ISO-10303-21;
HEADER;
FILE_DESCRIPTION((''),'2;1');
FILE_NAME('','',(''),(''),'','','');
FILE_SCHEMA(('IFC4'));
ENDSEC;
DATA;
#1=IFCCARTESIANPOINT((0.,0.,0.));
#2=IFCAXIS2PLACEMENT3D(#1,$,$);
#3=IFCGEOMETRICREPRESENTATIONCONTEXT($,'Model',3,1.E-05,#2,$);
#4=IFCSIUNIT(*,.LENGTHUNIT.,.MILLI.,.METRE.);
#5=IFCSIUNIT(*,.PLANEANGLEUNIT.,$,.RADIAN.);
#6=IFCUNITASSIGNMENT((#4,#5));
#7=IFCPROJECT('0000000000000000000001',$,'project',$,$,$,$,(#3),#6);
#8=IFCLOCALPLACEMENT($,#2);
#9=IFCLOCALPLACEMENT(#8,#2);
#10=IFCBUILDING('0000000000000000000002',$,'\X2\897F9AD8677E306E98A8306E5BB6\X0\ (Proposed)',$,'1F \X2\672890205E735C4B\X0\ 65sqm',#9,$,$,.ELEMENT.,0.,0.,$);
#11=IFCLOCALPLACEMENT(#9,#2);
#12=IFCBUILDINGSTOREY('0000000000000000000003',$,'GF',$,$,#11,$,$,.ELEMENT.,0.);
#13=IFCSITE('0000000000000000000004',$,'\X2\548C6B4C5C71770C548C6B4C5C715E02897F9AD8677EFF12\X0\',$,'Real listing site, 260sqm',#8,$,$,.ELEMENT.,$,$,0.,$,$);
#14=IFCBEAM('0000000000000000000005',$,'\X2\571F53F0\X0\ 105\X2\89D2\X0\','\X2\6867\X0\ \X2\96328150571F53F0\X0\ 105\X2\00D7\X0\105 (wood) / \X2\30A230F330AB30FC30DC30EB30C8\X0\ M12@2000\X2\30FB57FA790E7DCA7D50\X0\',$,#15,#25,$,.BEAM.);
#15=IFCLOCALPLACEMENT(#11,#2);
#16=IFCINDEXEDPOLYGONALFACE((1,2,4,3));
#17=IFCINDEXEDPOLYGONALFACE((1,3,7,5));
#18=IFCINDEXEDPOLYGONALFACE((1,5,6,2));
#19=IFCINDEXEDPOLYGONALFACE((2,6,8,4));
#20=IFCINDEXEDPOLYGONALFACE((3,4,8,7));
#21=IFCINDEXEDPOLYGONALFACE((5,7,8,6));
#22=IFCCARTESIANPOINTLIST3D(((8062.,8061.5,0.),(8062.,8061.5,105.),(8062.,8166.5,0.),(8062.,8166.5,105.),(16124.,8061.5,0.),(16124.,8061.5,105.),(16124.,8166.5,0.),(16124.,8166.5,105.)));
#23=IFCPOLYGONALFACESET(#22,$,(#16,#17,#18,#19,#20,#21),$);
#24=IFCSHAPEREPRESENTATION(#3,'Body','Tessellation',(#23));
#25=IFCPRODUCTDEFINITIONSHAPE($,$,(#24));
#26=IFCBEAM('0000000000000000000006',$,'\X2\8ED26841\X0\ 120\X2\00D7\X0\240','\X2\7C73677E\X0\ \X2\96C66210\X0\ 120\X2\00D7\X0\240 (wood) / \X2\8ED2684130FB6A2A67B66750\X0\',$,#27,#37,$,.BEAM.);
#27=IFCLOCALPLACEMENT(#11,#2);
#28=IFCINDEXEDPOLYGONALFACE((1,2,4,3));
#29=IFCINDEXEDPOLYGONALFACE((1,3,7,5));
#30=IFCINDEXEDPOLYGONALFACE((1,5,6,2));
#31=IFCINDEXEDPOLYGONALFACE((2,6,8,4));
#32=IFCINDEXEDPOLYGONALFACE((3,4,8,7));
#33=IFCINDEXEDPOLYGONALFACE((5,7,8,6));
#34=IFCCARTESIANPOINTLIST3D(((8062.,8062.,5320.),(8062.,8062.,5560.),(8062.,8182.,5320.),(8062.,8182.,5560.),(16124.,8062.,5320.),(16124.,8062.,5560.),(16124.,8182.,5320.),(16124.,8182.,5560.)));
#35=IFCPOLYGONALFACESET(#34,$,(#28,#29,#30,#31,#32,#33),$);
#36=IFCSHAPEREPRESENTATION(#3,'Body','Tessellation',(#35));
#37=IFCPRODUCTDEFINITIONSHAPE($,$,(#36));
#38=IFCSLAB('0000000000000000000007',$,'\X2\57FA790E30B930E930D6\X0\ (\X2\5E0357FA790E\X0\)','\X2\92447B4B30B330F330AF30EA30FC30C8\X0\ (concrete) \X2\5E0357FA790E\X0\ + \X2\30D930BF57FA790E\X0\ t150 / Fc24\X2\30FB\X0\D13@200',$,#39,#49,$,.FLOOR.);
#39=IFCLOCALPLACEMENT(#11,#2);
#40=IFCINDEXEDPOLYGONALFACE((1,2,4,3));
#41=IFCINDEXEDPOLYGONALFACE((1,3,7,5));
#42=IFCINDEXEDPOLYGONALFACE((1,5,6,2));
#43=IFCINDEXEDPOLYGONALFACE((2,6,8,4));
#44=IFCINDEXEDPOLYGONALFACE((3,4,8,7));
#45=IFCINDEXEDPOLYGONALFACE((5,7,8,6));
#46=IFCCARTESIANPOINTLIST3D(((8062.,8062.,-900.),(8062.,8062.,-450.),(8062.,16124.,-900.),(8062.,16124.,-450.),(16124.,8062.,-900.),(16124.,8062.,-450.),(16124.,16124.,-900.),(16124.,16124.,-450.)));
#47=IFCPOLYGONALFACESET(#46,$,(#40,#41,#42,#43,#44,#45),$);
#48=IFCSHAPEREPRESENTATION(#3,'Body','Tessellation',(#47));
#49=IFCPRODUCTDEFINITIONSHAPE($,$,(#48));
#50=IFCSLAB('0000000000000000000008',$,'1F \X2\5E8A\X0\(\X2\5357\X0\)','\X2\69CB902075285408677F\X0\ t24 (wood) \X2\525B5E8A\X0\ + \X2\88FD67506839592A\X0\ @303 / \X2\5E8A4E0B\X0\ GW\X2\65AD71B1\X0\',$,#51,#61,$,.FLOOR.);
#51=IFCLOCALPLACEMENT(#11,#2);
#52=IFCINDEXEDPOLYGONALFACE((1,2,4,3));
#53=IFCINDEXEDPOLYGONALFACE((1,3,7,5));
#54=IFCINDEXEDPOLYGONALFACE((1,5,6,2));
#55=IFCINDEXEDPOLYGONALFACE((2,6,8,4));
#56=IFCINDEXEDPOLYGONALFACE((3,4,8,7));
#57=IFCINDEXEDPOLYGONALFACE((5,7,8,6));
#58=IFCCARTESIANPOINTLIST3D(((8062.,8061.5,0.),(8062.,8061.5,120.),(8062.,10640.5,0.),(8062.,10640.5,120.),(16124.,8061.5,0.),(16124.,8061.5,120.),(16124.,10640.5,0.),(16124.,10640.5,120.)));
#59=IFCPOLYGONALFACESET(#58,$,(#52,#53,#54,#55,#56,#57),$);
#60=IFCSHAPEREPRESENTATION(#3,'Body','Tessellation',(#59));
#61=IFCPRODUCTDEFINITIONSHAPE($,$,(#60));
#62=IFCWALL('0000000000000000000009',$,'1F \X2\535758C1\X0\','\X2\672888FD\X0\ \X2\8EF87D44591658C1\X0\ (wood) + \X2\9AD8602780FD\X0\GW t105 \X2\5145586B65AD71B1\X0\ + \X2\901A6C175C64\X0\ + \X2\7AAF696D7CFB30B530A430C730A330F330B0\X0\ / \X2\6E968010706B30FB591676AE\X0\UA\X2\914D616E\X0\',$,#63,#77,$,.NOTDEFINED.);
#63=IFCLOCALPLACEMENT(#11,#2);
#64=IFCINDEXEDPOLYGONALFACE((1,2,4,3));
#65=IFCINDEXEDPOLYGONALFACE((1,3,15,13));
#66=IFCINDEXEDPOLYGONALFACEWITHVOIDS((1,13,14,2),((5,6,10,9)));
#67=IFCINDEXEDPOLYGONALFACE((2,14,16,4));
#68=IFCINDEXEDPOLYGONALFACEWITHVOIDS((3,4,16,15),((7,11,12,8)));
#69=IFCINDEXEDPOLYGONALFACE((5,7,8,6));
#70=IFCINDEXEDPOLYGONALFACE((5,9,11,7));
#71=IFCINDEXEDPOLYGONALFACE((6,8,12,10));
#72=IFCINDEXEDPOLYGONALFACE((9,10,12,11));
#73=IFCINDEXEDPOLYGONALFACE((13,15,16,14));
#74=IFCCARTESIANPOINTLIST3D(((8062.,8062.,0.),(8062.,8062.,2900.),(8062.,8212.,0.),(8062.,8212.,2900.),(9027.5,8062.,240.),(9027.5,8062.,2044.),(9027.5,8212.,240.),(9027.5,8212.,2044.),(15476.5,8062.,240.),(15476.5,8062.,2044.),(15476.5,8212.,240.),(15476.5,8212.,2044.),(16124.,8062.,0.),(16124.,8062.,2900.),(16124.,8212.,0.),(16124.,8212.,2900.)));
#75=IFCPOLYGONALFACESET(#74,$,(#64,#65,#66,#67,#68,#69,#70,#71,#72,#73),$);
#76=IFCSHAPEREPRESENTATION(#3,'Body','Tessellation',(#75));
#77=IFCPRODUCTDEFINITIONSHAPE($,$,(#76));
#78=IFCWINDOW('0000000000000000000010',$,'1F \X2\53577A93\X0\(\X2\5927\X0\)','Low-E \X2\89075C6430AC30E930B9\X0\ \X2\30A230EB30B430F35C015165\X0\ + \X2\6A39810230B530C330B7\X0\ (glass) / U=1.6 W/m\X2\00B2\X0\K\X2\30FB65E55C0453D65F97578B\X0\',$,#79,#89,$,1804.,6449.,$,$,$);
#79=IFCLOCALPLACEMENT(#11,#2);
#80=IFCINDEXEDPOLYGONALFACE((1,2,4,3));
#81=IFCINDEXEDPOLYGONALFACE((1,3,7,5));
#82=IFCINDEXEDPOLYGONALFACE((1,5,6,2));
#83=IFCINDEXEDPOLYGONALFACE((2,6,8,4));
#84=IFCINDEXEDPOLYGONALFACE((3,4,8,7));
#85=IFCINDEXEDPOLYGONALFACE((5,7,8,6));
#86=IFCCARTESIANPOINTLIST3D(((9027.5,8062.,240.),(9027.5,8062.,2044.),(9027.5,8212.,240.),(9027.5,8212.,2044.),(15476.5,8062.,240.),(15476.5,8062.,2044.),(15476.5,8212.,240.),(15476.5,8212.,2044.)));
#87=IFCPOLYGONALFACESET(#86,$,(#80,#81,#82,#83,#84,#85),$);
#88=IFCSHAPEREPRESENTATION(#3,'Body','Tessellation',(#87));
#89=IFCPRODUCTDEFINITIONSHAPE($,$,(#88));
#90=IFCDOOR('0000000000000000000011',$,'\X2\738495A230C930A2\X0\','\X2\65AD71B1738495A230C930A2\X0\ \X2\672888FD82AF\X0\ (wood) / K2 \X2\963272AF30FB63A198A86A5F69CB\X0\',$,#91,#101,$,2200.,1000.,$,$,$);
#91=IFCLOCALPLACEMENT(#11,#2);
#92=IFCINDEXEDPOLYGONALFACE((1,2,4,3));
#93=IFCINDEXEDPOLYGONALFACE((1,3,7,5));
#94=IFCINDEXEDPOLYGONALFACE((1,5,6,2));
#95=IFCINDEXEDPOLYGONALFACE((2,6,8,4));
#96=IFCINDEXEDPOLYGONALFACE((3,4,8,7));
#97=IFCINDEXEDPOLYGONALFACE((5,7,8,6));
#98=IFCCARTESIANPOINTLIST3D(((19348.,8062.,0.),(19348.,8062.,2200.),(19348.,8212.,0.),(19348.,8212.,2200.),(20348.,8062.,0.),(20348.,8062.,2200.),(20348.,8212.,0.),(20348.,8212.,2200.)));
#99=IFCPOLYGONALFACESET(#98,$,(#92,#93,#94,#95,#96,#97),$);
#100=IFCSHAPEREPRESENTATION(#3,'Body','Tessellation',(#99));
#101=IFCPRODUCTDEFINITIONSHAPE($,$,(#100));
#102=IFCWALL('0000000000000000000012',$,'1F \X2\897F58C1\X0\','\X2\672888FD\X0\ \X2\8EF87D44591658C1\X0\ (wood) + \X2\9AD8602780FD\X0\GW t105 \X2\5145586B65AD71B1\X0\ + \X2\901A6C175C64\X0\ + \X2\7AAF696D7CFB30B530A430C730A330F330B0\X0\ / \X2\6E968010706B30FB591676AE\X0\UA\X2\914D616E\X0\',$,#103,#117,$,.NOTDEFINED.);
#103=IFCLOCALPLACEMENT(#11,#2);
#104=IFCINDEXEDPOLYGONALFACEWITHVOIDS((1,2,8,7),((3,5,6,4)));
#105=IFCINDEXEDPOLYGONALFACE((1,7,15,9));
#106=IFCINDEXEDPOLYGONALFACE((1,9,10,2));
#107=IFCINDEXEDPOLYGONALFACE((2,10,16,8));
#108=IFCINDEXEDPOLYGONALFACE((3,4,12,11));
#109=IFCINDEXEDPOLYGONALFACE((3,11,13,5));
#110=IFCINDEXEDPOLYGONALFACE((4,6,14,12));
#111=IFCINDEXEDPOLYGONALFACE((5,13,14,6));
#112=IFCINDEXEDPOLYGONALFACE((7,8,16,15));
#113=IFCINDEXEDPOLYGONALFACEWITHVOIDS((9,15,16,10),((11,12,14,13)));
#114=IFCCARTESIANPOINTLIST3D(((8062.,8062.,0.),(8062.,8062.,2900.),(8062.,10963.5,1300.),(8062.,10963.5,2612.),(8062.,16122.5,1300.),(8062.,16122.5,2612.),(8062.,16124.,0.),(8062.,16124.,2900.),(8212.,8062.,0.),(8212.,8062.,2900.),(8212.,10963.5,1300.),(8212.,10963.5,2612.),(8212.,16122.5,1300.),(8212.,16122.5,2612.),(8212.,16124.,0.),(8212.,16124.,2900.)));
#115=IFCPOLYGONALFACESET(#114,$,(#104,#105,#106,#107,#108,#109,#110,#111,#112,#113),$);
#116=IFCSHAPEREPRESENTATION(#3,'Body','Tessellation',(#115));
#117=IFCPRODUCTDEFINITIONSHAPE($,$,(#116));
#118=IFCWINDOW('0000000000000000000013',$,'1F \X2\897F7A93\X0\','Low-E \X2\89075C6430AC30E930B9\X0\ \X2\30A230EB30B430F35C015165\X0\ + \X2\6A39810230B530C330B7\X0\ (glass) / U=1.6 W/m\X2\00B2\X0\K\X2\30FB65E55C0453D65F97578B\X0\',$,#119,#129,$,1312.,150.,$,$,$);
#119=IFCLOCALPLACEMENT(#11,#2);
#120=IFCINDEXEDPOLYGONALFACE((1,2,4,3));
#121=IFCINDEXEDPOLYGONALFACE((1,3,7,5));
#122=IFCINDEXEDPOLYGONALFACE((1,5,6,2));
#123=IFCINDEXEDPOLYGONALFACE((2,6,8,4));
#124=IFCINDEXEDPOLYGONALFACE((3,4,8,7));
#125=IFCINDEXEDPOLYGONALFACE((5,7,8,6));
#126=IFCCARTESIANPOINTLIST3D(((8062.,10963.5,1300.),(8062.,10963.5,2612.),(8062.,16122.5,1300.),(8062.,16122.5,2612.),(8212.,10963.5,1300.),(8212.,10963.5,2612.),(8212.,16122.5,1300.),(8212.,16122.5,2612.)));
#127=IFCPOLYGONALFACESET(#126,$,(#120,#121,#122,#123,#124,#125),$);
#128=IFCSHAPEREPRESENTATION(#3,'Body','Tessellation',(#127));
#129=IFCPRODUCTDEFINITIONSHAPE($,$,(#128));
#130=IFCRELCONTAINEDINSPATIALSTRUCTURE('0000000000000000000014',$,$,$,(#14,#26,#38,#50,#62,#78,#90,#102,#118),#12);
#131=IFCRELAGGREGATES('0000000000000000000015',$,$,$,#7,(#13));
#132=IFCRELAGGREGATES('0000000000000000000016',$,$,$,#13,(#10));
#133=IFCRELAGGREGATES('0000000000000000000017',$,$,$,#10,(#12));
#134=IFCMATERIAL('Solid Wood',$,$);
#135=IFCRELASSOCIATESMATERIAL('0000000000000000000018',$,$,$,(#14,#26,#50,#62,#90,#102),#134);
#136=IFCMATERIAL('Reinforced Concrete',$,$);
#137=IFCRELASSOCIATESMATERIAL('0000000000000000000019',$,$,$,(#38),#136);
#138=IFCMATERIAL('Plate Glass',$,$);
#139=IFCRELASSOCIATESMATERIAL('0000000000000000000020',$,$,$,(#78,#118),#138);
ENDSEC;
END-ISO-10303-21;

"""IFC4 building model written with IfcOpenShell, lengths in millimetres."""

from ifc_helpers import new_model, si_unit, frame, frame_2d, origin, place, context, project, spatial, rectangle, extrude, material, element, fill, save


model = new_model("IFC4")

# Units and contexts
model_context = context("Model", 3, precision=1e-05, world=origin())
ifc_project = project(units=[si_unit("LENGTHUNIT", "METRE", prefix="MILLI"), si_unit("PLANEANGLEUNIT", "RADIAN")], contexts=[model_context])

# Site, building, storey
site_placement = place(None, origin())
site = spatial("IfcSite", under=ifc_project, at=site_placement, Name="和歌山県和歌山市西高松２", ObjectType="Real listing site, 260sqm", CompositionType="ELEMENT", RefElevation=0.0)
building_placement = place(site_placement, origin())
building = spatial("IfcBuilding", under=site, at=building_placement, Name="西高松の風の家 (Proposed)", ObjectType="1F 木造平屋 65sqm", CompositionType="ELEMENT", ElevationOfRefHeight=0.0, ElevationOfTerrain=0.0)
storey_placement = place(building_placement, origin())
storey = spatial("IfcBuildingStorey", under=building, at=storey_placement, Name="GF", CompositionType="ELEMENT", Elevation=0.0)

# Shared definitions
ifc_material_1 = material(Name="Solid Wood")

# Beams
beam_1_placement = place(storey_placement, frame((4031.0, 4031.0, 0.0)))
element("IfcBeam", 1, at=beam_1_placement, inside=storey, material=ifc_material_1, Name="土台 105角", Description="桧 防腐土台 105×105 (wood) / アンカーボルト M12@2000・基礎緊結", PredefinedType="BEAM", context=model_context, shape_type="SweptSolid", body=[
    extrude(rectangle(XDim=8062.0, YDim=105.0, at=frame_2d((4031.0, 52.0))), frame((4031.0, 4031.0, 0.0)), (0.0, 0.0, 1.0), 105.0),
])
beam_2_placement = place(storey_placement, frame((4031.0, 4031.0, 2660.0)))
element("IfcBeam", 2, at=beam_2_placement, inside=storey, material=ifc_material_1, Name="軒桁 120×240", Description="米松 集成 120×240 (wood) / 軒桁・横架材", PredefinedType="BEAM", context=model_context, shape_type="SweptSolid", body=[
    extrude(rectangle(XDim=8062.0, YDim=120.0, at=frame_2d((4031.0, 60.0))), frame((4031.0, 4031.0, 2660.0)), (0.0, 0.0, 1.0), 240.0),
])

# Slabs
ifc_material_2 = material(Name="Reinforced Concrete")
slab_1_placement = place(storey_placement, frame((4031.0, 4031.0, -450.0)))
element("IfcSlab", 3, at=slab_1_placement, inside=storey, material=ifc_material_2, Name="基礎スラブ (布基礎)", Description="鉄筋コンクリート (concrete) 布基礎 + ベタ基礎 t150 / Fc24・D13@200", PredefinedType="FLOOR", context=model_context, shape_type="SweptSolid", body=[
    extrude(rectangle(XDim=8062.0, YDim=8062.0, at=frame_2d((4031.0, 4031.0))), frame((4031.0, 4031.0, -450.0)), (0.0, 0.0, 1.0), 450.0),
])
slab_2_placement = place(storey_placement, frame((4031.0, 4031.0, 0.0)))
element("IfcSlab", 4, at=slab_2_placement, inside=storey, material=ifc_material_1, Name="1F 床(南)", Description="構造用合板 t24 (wood) 剛床 + 製材根太 @303 / 床下 GW断熱", PredefinedType="FLOOR", context=model_context, shape_type="SweptSolid", body=[
    extrude(rectangle(XDim=8062.0, YDim=2579.0, at=frame_2d((4031.0, 1289.0))), frame((4031.0, 4031.0, 0.0)), (0.0, 0.0, 1.0), 120.0),
])

# Wall, openings, window, door
wall_1_placement = place(storey_placement, frame((4031.0, 4031.0, 0.0)))
wall_1 = element("IfcWall", 5, at=wall_1_placement, inside=storey, material=ifc_material_1, Name="1F 南壁", Description="木製 軸組外壁 (wood) + 高性能GW t105 充填断熱 + 通気層 + 窯業系サイディング / 準耐火・外皮UA配慮", PredefinedType="NOTDEFINED", context=model_context, shape_type="SweptSolid", body=[
    extrude(rectangle(XDim=8062.0, YDim=150.0, at=frame_2d((4031.0, 75.0))), frame((4031.0, 4031.0, 0.0)), (0.0, 0.0, 1.0), 2900.0),
])
opening_1_placement = place(storey_placement, frame((4514.0, 4031.0, 120.0)))
opening_1 = element("IfcOpeningElement", 6, at=opening_1_placement, cuts=wall_1, PredefinedType="NOTDEFINED", context=model_context, shape_type="SweptSolid", body=[
    extrude(rectangle(XDim=6449.0, YDim=150.0, at=frame_2d((3224.0, 75.0))), frame((4514.0, 4031.0, 120.0)), (0.0, 0.0, 1.0), 1804.0),
])
opening_2_placement = place(storey_placement, frame((9674.0, 4031.0, 0.0)))
opening_2 = element("IfcOpeningElement", 7, at=opening_2_placement, cuts=wall_1, PredefinedType="NOTDEFINED", context=model_context, shape_type="SweptSolid", body=[
    extrude(rectangle(XDim=1000.0, YDim=150.0, at=frame_2d((500.0, 75.0))), frame((9674.0, 4031.0, 0.0)), (0.0, 0.0, 1.0), 2200.0),
])
ifc_material_3 = material(Name="Plate Glass")
window_1_placement = place(storey_placement, frame((4514.0, 4031.0, 120.0)))
window_1 = element("IfcWindow", 8, at=window_1_placement, inside=storey, material=ifc_material_3, Name="1F 南窓(大)", Description="Low-E 複層ガラス アルゴン封入 + 樹脂サッシ (glass) / U=1.6 W/m²K・日射取得型", OverallHeight=1804.0, OverallWidth=6449.0, context=model_context, shape_type="SweptSolid", body=[
    extrude(rectangle(XDim=6449.0, YDim=150.0, at=frame_2d((3224.0, 75.0))), frame((4514.0, 4031.0, 120.0)), (0.0, 0.0, 1.0), 1804.0),
])
fill(opening_1, window_1)
door_placement = place(storey_placement, frame((9674.0, 4031.0, 0.0)))
door = element("IfcDoor", 9, at=door_placement, inside=storey, material=ifc_material_1, Name="玄関ドア", Description="断熱玄関ドア 木製芯 (wood) / K2 防犯・採風機構", OverallHeight=2200.0, OverallWidth=1000.0, context=model_context, shape_type="SweptSolid", body=[
    extrude(rectangle(XDim=1000.0, YDim=150.0, at=frame_2d((500.0, 75.0))), frame((9674.0, 4031.0, 0.0)), (0.0, 0.0, 1.0), 2200.0),
])
fill(opening_2, door)

# Wall, opening, window
wall_2_placement = place(storey_placement, frame((4031.0, 4031.0, 0.0)))
wall_2 = element("IfcWall", 10, at=wall_2_placement, inside=storey, material=ifc_material_1, Name="1F 西壁", Description="木製 軸組外壁 (wood) + 高性能GW t105 充填断熱 + 通気層 + 窯業系サイディング / 準耐火・外皮UA配慮", PredefinedType="NOTDEFINED", context=model_context, shape_type="SweptSolid", body=[
    extrude(rectangle(XDim=150.0, YDim=8062.0, at=frame_2d((75.0, 4031.0))), frame((4031.0, 4031.0, 0.0)), (0.0, 0.0, 1.0), 2900.0),
])
opening_3_placement = place(storey_placement, frame((4031.0, 5482.0, 650.0)))
opening_3 = element("IfcOpeningElement", 11, at=opening_3_placement, cuts=wall_2, PredefinedType="NOTDEFINED", context=model_context, shape_type="SweptSolid", body=[
    extrude(rectangle(XDim=150.0, YDim=5159.0, at=frame_2d((75.0, 2579.0))), frame((4031.0, 5482.0, 650.0)), (0.0, 0.0, 1.0), 1312.0),
])
window_2_placement = place(storey_placement, frame((4031.0, 5482.0, 650.0)))
window_2 = element("IfcWindow", 12, at=window_2_placement, inside=storey, material=ifc_material_3, Name="1F 西窓", Description="Low-E 複層ガラス アルゴン封入 + 樹脂サッシ (glass) / U=1.6 W/m²K・日射取得型", OverallHeight=1312.0, OverallWidth=150.0, context=model_context, shape_type="SweptSolid", body=[
    extrude(rectangle(XDim=150.0, YDim=5159.0, at=frame_2d((75.0, 2579.0))), frame((4031.0, 5482.0, 650.0)), (0.0, 0.0, 1.0), 1312.0),
])
fill(opening_3, window_2)

save(model, "model.ifc")
